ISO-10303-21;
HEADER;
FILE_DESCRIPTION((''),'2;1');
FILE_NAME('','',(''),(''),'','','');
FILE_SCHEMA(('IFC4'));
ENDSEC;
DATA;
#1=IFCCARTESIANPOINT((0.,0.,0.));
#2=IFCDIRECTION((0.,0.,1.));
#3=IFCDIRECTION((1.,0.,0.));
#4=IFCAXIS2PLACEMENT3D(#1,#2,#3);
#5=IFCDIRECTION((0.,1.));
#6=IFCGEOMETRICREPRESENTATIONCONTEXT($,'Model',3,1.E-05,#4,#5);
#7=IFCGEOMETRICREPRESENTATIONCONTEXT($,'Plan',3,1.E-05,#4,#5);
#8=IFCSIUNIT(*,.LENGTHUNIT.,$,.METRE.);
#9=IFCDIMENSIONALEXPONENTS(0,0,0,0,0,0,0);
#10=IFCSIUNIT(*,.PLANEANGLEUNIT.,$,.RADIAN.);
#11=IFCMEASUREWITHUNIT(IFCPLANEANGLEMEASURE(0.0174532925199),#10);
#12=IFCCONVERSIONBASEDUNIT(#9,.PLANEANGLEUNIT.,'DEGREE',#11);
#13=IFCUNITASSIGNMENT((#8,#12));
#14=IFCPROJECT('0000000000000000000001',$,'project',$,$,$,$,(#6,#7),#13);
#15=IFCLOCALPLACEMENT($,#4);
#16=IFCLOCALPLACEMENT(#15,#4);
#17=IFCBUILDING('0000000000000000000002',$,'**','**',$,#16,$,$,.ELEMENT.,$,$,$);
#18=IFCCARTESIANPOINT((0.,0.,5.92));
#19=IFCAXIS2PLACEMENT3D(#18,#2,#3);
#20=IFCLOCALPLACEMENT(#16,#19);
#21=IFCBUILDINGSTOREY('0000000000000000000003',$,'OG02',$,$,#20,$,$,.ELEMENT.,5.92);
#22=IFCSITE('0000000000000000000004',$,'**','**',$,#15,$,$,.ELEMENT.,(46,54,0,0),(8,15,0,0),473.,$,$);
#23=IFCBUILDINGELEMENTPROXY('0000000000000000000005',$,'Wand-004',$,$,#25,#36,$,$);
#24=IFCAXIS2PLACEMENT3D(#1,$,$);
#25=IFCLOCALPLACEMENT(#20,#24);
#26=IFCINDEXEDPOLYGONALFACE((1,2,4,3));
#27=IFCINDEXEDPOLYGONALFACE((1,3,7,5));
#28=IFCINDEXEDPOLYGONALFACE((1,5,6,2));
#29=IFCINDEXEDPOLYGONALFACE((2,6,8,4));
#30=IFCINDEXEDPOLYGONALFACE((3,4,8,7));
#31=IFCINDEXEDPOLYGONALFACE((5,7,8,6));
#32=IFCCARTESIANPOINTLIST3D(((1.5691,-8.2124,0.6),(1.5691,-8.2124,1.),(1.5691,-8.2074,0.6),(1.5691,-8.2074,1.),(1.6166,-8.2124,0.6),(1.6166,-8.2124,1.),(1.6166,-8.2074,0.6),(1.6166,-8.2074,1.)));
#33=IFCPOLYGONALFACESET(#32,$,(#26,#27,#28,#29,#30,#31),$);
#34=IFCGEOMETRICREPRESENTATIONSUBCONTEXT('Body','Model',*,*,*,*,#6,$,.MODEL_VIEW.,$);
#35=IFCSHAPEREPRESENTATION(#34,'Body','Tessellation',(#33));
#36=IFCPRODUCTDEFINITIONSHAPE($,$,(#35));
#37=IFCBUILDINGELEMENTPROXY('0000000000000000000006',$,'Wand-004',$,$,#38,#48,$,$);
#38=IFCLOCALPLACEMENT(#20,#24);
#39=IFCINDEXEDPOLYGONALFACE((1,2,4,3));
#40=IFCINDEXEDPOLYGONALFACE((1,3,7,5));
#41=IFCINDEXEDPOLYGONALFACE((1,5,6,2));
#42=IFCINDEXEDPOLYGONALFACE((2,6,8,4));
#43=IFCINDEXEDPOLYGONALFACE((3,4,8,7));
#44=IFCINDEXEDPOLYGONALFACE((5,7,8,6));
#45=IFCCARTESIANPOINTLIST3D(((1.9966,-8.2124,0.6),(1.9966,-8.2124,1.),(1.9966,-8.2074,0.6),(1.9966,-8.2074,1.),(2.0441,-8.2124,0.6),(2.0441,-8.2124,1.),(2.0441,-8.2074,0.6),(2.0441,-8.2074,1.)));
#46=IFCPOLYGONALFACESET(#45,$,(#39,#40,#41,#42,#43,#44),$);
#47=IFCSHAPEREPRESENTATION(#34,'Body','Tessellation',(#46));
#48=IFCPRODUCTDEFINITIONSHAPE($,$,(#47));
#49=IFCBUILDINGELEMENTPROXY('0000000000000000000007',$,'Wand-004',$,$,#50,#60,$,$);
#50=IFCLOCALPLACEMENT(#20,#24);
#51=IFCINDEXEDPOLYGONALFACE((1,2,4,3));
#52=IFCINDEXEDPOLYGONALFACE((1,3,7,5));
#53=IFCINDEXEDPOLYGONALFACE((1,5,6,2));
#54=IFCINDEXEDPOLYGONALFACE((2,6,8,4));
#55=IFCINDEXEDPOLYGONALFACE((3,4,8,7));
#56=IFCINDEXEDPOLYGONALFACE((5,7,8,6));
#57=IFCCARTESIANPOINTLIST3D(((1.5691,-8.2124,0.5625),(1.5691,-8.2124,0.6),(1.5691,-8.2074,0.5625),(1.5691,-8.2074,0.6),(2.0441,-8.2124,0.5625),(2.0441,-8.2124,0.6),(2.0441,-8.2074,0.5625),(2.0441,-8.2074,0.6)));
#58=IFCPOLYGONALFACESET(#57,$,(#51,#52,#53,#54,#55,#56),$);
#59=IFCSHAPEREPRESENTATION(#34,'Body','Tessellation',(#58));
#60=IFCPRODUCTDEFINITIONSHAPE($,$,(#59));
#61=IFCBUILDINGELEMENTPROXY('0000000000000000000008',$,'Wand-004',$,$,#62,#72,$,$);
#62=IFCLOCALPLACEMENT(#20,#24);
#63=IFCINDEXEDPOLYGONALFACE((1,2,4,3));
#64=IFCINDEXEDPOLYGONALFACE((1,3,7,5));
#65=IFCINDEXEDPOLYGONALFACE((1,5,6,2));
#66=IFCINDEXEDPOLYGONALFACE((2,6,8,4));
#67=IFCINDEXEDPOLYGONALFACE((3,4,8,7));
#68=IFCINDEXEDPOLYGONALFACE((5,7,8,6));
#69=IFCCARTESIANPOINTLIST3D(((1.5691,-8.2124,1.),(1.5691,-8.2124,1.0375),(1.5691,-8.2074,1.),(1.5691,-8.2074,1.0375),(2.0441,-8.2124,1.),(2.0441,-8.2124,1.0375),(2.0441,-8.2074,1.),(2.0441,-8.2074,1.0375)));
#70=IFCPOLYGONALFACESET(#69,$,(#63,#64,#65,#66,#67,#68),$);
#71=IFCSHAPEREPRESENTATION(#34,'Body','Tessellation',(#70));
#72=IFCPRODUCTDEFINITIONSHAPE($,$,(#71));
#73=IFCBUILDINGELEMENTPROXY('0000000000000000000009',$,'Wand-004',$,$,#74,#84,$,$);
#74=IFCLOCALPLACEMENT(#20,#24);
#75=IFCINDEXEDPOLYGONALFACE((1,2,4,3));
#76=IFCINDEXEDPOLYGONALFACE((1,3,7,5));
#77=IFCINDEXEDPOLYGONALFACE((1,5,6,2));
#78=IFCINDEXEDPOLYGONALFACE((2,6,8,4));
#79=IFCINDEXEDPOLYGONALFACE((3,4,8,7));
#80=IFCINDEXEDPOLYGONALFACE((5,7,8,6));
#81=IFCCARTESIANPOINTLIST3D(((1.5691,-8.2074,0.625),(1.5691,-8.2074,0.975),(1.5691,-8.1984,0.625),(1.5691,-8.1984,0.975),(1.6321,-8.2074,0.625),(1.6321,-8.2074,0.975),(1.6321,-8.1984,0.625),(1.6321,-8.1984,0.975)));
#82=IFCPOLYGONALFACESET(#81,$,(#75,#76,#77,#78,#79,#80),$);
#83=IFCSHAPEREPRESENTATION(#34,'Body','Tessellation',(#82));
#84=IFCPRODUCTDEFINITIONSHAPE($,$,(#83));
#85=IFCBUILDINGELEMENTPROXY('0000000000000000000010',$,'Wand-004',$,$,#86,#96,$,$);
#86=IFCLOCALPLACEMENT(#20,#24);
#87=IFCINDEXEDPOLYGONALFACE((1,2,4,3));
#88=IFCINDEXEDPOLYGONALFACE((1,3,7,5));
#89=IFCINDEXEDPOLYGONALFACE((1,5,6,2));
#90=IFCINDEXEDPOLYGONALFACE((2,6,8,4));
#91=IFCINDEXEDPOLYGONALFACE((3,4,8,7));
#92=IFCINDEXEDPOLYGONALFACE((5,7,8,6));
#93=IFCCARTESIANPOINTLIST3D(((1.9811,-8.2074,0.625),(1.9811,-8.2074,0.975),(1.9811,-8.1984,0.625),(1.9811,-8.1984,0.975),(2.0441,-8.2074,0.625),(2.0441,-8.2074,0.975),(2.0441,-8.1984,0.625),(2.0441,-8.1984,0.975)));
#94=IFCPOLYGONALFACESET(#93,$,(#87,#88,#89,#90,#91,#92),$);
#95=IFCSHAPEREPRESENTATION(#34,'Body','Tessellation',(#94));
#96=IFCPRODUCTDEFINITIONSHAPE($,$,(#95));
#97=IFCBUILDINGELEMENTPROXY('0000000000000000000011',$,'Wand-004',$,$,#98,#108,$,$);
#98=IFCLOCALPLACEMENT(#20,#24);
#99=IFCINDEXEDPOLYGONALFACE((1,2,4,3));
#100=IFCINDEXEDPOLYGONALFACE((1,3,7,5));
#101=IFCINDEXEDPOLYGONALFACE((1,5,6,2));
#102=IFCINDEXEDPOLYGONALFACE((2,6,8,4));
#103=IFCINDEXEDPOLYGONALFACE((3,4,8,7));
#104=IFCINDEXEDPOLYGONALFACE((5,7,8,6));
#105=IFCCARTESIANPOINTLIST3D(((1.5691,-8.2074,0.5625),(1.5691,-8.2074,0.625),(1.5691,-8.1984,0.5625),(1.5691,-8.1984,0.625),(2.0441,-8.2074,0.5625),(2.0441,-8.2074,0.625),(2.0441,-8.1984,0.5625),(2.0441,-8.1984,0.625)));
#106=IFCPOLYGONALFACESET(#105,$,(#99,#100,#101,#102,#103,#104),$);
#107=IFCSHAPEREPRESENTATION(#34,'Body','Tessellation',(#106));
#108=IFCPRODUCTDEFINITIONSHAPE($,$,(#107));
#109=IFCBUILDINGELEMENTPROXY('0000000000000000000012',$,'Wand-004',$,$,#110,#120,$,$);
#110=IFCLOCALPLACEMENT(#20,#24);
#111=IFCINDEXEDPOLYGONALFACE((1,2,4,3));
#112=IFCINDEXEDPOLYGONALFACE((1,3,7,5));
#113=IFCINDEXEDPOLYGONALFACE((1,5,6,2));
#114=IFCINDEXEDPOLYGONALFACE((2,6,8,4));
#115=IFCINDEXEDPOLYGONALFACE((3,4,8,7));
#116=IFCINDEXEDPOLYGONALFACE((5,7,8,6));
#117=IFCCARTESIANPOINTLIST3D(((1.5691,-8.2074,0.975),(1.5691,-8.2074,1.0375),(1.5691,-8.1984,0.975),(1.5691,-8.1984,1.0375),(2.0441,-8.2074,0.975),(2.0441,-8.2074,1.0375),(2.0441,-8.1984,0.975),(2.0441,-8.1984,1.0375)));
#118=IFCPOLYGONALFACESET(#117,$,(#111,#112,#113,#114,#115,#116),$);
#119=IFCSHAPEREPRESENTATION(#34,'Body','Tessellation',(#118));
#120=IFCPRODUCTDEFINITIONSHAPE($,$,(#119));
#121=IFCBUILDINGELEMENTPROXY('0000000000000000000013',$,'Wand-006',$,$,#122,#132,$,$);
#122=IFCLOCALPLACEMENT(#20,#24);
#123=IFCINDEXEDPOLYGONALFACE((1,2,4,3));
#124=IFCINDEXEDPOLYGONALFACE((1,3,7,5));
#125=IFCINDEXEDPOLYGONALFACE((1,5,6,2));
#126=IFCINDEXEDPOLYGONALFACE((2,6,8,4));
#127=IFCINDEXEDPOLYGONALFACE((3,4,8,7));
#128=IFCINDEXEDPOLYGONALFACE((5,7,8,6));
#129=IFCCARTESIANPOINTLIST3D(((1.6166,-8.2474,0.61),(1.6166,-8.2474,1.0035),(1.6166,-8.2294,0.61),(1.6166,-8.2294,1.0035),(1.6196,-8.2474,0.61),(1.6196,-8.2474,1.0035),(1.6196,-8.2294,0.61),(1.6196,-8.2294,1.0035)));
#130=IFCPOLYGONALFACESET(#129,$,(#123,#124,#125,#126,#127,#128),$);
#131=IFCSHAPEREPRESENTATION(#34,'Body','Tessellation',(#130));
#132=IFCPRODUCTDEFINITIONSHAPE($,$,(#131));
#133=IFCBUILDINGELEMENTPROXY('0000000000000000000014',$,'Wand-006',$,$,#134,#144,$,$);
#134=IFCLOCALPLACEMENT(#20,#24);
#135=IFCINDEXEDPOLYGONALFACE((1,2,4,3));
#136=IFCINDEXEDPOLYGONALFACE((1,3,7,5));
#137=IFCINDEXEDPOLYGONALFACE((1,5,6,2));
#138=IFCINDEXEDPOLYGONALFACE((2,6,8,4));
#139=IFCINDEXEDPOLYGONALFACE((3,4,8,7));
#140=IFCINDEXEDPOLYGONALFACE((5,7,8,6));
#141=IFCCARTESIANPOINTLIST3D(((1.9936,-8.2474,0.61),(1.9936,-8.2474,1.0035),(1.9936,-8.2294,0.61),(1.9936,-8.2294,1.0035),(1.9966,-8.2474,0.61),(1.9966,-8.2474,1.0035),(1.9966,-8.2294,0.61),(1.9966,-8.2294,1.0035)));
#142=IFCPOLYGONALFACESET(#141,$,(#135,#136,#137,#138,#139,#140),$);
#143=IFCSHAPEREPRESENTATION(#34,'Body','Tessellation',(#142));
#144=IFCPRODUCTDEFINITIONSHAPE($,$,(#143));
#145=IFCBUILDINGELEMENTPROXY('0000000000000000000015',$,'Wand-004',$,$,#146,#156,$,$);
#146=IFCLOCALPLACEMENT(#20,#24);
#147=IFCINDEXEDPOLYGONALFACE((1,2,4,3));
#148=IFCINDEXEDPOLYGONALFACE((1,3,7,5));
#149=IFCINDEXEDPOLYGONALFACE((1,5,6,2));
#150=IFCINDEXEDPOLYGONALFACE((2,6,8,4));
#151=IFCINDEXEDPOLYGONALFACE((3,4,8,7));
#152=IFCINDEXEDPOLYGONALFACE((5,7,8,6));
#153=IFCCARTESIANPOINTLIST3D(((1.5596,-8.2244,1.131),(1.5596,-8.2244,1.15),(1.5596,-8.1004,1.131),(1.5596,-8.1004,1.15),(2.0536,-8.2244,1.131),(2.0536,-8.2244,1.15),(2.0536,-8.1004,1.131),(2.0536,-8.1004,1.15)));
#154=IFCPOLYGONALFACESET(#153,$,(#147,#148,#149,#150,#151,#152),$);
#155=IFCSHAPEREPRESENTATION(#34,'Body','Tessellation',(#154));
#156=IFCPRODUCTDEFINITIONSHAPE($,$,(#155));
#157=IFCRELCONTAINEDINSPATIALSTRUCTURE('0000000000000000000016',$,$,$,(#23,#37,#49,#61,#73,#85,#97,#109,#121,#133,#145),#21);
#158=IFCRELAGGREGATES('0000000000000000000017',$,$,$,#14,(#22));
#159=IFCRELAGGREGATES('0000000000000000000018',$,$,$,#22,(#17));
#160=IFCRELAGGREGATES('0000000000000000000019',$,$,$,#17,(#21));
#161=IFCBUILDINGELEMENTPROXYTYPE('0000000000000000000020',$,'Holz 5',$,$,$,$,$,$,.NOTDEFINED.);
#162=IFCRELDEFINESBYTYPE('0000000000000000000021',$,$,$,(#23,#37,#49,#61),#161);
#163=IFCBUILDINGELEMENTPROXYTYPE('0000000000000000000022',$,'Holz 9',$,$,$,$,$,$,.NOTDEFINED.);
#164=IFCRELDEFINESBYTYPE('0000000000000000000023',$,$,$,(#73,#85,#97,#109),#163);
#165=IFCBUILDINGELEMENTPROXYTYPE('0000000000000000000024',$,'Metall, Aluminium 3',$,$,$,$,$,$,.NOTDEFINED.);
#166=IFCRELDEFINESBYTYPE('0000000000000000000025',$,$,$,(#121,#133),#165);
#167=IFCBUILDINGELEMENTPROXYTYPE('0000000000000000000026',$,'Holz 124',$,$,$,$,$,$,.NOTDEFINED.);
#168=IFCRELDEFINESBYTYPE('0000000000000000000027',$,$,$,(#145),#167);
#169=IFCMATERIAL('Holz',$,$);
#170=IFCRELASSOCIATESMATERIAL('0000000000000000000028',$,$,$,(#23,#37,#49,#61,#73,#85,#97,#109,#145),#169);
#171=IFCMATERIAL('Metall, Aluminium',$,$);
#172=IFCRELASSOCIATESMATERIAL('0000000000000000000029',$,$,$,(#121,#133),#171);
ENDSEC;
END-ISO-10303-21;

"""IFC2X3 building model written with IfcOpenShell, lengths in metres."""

from ifc_helpers import new_model, entity, si_unit, converted_unit, direction, frame, origin_with_axes, place, context, subcontext, project, spatial, polyline, outline, extrude, material, type_object, element, save


model = new_model("IFC2X3")

# Units and contexts
model_context = context("Model", 3, precision=1e-05, world=origin_with_axes(), true_north=direction((0.0, 1.0)))
plan_context = context("Plan", 3, precision=1e-05, world=origin_with_axes(), true_north=direction((0.0, 1.0)))
body_context = subcontext(model_context, "Body", "Model", "MODEL_VIEW")
ifc_project = project(units=[si_unit("LENGTHUNIT", "METRE"), converted_unit("PLANEANGLEUNIT", "DEGREE", entity("IfcPlaneAngleMeasure", 0.0174532925199), si_unit("PLANEANGLEUNIT", "RADIAN"), dimensions=[0, 0, 0, 0, 0, 0, 0])], contexts=[model_context, plan_context])

# Site, building, storey
site_placement = place(None, origin_with_axes())
site = spatial("IfcSite", under=ifc_project, at=site_placement, Name="**", Description="**", CompositionType="ELEMENT", RefLatitude=(46, 54, 0, 0), RefLongitude=(8, 15, 0, 0), RefElevation=473.0)
building_placement = place(site_placement, origin_with_axes())
building = spatial("IfcBuilding", under=site, at=building_placement, Name="**", Description="**", CompositionType="ELEMENT")
storey_placement = place(building_placement, frame((0.0, 0.0, 5.92), z_axis=(0.0, 0.0, 1.0), x_axis=(1.0, 0.0, 0.0)))
storey = spatial("IfcBuildingStorey", under=building, at=storey_placement, Name="OG02", CompositionType="ELEMENT", Elevation=5.92)

# Building element proxies
ifc_material_1 = material(Name="Holz")
building_element_proxy_type_1 = type_object("IfcBuildingElementProxyType", Name="Holz 5", PredefinedType="NOTDEFINED")
for number, where, z_axis, x_axis, name in (
    (1, (1.5691, -8.2124, 0.6), (0.0, 0.0, 1.0), (1.0, 0.0, 0.0), "Wand-004"),
    (2, (1.9966, -8.2124, 0.6), (0.0, 0.0, 1.0), (1.0, 0.0, 0.0), "Wand-004"),
):
    element("IfcBuildingElementProxy", number, at=place(storey_placement, frame(where, z_axis=z_axis, x_axis=x_axis)), inside=storey, type_object=building_element_proxy_type_1, material=ifc_material_1, Name=name, context=body_context, shape_type="SweptSolid", body=[
        extrude(outline(polyline([(0.0, 0.0), (0.0475, 0.0), (0.0475, 0.005), (0.0, 0.005), (0.0, 0.0)])), origin_with_axes(), (0.0, 0.0, 1.0), 0.4),
    ])
for number, where, z_axis, x_axis, name in (
    (3, (2.0441, -8.2124, 0.5625), (0.0, 0.0, 1.0), (-1.0, 0.0, 0.0), "Wand-004"),
    (4, (2.0441, -8.2124, 1.0), (0.0, 0.0, 1.0), (-1.0, 0.0, 0.0), "Wand-004"),
):
    element("IfcBuildingElementProxy", number, at=place(storey_placement, frame(where, z_axis=z_axis, x_axis=x_axis)), inside=storey, type_object=building_element_proxy_type_1, material=ifc_material_1, Name=name, context=body_context, shape_type="SweptSolid", body=[
        extrude(outline(polyline([(0.0, -0.005), (0.475, -0.005), (0.475, 0.0), (0.0, 0.0), (0.0, -0.005)])), origin_with_axes(), (0.0, 0.0, 1.0), 0.0375),
    ])
building_element_proxy_type_2 = type_object("IfcBuildingElementProxyType", Name="Holz 9", PredefinedType="NOTDEFINED")
for number, where, z_axis, x_axis, name in (
    (5, (1.5691, -8.2074, 0.625), (0.0, 0.0, 1.0), (1.0, 0.0, 0.0), "Wand-004"),
    (6, (1.9811, -8.2074, 0.625), (0.0, 0.0, 1.0), (1.0, 0.0, 0.0), "Wand-004"),
):
    element("IfcBuildingElementProxy", number, at=place(storey_placement, frame(where, z_axis=z_axis, x_axis=x_axis)), inside=storey, type_object=building_element_proxy_type_2, material=ifc_material_1, Name=name, context=body_context, shape_type="SweptSolid", body=[
        extrude(outline(polyline([(0.0, 0.0), (0.063, 0.0), (0.063, 0.009), (0.0, 0.009), (0.0, 0.0)])), origin_with_axes(), (0.0, 0.0, 1.0), 0.35),
    ])
for number, where, z_axis, x_axis, name in (
    (7, (2.0441, -8.2074, 0.5625), (0.0, 0.0, 1.0), (-1.0, 0.0, 0.0), "Wand-004"),
    (8, (2.0441, -8.2074, 0.975), (0.0, 0.0, 1.0), (-1.0, 0.0, 0.0), "Wand-004"),
):
    element("IfcBuildingElementProxy", number, at=place(storey_placement, frame(where, z_axis=z_axis, x_axis=x_axis)), inside=storey, type_object=building_element_proxy_type_2, material=ifc_material_1, Name=name, context=body_context, shape_type="SweptSolid", body=[
        extrude(outline(polyline([(0.0, -0.009), (0.475, -0.009), (0.475, 0.0), (0.0, 0.0), (0.0, -0.009)])), origin_with_axes(), (0.0, 0.0, 1.0), 0.0625),
    ])
ifc_material_2 = material(Name="Metall, Aluminium")
building_element_proxy_type_3 = type_object("IfcBuildingElementProxyType", Name="Metall, Aluminium 3", PredefinedType="NOTDEFINED")
proxy_1_placement = place(storey_placement, frame((1.6166, -8.2294, 0.61), z_axis=(0.0, 0.0, 1.0), x_axis=(0.0, -1.0, 0.0)))
element("IfcBuildingElementProxy", 9, at=proxy_1_placement, inside=storey, type_object=building_element_proxy_type_3, material=ifc_material_2, Name="Wand-006", context=body_context, shape_type="SweptSolid", body=[
    extrude(outline(polyline([(0.0, 0.0), (0.018, 0.0), (0.018, 0.003), (0.0, 0.003), (0.0, 0.0)])), origin_with_axes(), (0.0, 0.0, 1.0), 0.3935),
])
proxy_2_placement = place(storey_placement, frame((1.9966, -8.2294, 0.61), z_axis=(0.0, 0.0, 1.0), x_axis=(0.0, -1.0, 0.0)))
element("IfcBuildingElementProxy", 10, at=proxy_2_placement, inside=storey, type_object=building_element_proxy_type_3, material=ifc_material_2, Name="Wand-006", context=body_context, shape_type="SweptSolid", body=[
    extrude(outline(polyline([(0.0, -0.003), (0.018, -0.003), (0.018, 0.0), (0.0, 0.0), (0.0, -0.003)])), origin_with_axes(), (0.0, 0.0, 1.0), 0.3935),
])
building_element_proxy_type_4 = type_object("IfcBuildingElementProxyType", Name="Holz 124", PredefinedType="NOTDEFINED")
proxy_3_placement = place(storey_placement, frame((1.5596, -8.1004, 1.131), z_axis=(0.0, 0.0, 1.0), x_axis=(1.0, 0.0, 0.0)))
element("IfcBuildingElementProxy", 11, at=proxy_3_placement, inside=storey, type_object=building_element_proxy_type_4, material=ifc_material_1, Name="Wand-004", context=body_context, shape_type="SweptSolid", body=[
    extrude(outline(polyline([(0.0, -0.124), (0.494, -0.124), (0.494, 0.0), (0.0, 0.0), (0.0, -0.124)])), origin_with_axes(), (0.0, 0.0, 1.0), 0.019),
])

save(model, "model.ifc")
